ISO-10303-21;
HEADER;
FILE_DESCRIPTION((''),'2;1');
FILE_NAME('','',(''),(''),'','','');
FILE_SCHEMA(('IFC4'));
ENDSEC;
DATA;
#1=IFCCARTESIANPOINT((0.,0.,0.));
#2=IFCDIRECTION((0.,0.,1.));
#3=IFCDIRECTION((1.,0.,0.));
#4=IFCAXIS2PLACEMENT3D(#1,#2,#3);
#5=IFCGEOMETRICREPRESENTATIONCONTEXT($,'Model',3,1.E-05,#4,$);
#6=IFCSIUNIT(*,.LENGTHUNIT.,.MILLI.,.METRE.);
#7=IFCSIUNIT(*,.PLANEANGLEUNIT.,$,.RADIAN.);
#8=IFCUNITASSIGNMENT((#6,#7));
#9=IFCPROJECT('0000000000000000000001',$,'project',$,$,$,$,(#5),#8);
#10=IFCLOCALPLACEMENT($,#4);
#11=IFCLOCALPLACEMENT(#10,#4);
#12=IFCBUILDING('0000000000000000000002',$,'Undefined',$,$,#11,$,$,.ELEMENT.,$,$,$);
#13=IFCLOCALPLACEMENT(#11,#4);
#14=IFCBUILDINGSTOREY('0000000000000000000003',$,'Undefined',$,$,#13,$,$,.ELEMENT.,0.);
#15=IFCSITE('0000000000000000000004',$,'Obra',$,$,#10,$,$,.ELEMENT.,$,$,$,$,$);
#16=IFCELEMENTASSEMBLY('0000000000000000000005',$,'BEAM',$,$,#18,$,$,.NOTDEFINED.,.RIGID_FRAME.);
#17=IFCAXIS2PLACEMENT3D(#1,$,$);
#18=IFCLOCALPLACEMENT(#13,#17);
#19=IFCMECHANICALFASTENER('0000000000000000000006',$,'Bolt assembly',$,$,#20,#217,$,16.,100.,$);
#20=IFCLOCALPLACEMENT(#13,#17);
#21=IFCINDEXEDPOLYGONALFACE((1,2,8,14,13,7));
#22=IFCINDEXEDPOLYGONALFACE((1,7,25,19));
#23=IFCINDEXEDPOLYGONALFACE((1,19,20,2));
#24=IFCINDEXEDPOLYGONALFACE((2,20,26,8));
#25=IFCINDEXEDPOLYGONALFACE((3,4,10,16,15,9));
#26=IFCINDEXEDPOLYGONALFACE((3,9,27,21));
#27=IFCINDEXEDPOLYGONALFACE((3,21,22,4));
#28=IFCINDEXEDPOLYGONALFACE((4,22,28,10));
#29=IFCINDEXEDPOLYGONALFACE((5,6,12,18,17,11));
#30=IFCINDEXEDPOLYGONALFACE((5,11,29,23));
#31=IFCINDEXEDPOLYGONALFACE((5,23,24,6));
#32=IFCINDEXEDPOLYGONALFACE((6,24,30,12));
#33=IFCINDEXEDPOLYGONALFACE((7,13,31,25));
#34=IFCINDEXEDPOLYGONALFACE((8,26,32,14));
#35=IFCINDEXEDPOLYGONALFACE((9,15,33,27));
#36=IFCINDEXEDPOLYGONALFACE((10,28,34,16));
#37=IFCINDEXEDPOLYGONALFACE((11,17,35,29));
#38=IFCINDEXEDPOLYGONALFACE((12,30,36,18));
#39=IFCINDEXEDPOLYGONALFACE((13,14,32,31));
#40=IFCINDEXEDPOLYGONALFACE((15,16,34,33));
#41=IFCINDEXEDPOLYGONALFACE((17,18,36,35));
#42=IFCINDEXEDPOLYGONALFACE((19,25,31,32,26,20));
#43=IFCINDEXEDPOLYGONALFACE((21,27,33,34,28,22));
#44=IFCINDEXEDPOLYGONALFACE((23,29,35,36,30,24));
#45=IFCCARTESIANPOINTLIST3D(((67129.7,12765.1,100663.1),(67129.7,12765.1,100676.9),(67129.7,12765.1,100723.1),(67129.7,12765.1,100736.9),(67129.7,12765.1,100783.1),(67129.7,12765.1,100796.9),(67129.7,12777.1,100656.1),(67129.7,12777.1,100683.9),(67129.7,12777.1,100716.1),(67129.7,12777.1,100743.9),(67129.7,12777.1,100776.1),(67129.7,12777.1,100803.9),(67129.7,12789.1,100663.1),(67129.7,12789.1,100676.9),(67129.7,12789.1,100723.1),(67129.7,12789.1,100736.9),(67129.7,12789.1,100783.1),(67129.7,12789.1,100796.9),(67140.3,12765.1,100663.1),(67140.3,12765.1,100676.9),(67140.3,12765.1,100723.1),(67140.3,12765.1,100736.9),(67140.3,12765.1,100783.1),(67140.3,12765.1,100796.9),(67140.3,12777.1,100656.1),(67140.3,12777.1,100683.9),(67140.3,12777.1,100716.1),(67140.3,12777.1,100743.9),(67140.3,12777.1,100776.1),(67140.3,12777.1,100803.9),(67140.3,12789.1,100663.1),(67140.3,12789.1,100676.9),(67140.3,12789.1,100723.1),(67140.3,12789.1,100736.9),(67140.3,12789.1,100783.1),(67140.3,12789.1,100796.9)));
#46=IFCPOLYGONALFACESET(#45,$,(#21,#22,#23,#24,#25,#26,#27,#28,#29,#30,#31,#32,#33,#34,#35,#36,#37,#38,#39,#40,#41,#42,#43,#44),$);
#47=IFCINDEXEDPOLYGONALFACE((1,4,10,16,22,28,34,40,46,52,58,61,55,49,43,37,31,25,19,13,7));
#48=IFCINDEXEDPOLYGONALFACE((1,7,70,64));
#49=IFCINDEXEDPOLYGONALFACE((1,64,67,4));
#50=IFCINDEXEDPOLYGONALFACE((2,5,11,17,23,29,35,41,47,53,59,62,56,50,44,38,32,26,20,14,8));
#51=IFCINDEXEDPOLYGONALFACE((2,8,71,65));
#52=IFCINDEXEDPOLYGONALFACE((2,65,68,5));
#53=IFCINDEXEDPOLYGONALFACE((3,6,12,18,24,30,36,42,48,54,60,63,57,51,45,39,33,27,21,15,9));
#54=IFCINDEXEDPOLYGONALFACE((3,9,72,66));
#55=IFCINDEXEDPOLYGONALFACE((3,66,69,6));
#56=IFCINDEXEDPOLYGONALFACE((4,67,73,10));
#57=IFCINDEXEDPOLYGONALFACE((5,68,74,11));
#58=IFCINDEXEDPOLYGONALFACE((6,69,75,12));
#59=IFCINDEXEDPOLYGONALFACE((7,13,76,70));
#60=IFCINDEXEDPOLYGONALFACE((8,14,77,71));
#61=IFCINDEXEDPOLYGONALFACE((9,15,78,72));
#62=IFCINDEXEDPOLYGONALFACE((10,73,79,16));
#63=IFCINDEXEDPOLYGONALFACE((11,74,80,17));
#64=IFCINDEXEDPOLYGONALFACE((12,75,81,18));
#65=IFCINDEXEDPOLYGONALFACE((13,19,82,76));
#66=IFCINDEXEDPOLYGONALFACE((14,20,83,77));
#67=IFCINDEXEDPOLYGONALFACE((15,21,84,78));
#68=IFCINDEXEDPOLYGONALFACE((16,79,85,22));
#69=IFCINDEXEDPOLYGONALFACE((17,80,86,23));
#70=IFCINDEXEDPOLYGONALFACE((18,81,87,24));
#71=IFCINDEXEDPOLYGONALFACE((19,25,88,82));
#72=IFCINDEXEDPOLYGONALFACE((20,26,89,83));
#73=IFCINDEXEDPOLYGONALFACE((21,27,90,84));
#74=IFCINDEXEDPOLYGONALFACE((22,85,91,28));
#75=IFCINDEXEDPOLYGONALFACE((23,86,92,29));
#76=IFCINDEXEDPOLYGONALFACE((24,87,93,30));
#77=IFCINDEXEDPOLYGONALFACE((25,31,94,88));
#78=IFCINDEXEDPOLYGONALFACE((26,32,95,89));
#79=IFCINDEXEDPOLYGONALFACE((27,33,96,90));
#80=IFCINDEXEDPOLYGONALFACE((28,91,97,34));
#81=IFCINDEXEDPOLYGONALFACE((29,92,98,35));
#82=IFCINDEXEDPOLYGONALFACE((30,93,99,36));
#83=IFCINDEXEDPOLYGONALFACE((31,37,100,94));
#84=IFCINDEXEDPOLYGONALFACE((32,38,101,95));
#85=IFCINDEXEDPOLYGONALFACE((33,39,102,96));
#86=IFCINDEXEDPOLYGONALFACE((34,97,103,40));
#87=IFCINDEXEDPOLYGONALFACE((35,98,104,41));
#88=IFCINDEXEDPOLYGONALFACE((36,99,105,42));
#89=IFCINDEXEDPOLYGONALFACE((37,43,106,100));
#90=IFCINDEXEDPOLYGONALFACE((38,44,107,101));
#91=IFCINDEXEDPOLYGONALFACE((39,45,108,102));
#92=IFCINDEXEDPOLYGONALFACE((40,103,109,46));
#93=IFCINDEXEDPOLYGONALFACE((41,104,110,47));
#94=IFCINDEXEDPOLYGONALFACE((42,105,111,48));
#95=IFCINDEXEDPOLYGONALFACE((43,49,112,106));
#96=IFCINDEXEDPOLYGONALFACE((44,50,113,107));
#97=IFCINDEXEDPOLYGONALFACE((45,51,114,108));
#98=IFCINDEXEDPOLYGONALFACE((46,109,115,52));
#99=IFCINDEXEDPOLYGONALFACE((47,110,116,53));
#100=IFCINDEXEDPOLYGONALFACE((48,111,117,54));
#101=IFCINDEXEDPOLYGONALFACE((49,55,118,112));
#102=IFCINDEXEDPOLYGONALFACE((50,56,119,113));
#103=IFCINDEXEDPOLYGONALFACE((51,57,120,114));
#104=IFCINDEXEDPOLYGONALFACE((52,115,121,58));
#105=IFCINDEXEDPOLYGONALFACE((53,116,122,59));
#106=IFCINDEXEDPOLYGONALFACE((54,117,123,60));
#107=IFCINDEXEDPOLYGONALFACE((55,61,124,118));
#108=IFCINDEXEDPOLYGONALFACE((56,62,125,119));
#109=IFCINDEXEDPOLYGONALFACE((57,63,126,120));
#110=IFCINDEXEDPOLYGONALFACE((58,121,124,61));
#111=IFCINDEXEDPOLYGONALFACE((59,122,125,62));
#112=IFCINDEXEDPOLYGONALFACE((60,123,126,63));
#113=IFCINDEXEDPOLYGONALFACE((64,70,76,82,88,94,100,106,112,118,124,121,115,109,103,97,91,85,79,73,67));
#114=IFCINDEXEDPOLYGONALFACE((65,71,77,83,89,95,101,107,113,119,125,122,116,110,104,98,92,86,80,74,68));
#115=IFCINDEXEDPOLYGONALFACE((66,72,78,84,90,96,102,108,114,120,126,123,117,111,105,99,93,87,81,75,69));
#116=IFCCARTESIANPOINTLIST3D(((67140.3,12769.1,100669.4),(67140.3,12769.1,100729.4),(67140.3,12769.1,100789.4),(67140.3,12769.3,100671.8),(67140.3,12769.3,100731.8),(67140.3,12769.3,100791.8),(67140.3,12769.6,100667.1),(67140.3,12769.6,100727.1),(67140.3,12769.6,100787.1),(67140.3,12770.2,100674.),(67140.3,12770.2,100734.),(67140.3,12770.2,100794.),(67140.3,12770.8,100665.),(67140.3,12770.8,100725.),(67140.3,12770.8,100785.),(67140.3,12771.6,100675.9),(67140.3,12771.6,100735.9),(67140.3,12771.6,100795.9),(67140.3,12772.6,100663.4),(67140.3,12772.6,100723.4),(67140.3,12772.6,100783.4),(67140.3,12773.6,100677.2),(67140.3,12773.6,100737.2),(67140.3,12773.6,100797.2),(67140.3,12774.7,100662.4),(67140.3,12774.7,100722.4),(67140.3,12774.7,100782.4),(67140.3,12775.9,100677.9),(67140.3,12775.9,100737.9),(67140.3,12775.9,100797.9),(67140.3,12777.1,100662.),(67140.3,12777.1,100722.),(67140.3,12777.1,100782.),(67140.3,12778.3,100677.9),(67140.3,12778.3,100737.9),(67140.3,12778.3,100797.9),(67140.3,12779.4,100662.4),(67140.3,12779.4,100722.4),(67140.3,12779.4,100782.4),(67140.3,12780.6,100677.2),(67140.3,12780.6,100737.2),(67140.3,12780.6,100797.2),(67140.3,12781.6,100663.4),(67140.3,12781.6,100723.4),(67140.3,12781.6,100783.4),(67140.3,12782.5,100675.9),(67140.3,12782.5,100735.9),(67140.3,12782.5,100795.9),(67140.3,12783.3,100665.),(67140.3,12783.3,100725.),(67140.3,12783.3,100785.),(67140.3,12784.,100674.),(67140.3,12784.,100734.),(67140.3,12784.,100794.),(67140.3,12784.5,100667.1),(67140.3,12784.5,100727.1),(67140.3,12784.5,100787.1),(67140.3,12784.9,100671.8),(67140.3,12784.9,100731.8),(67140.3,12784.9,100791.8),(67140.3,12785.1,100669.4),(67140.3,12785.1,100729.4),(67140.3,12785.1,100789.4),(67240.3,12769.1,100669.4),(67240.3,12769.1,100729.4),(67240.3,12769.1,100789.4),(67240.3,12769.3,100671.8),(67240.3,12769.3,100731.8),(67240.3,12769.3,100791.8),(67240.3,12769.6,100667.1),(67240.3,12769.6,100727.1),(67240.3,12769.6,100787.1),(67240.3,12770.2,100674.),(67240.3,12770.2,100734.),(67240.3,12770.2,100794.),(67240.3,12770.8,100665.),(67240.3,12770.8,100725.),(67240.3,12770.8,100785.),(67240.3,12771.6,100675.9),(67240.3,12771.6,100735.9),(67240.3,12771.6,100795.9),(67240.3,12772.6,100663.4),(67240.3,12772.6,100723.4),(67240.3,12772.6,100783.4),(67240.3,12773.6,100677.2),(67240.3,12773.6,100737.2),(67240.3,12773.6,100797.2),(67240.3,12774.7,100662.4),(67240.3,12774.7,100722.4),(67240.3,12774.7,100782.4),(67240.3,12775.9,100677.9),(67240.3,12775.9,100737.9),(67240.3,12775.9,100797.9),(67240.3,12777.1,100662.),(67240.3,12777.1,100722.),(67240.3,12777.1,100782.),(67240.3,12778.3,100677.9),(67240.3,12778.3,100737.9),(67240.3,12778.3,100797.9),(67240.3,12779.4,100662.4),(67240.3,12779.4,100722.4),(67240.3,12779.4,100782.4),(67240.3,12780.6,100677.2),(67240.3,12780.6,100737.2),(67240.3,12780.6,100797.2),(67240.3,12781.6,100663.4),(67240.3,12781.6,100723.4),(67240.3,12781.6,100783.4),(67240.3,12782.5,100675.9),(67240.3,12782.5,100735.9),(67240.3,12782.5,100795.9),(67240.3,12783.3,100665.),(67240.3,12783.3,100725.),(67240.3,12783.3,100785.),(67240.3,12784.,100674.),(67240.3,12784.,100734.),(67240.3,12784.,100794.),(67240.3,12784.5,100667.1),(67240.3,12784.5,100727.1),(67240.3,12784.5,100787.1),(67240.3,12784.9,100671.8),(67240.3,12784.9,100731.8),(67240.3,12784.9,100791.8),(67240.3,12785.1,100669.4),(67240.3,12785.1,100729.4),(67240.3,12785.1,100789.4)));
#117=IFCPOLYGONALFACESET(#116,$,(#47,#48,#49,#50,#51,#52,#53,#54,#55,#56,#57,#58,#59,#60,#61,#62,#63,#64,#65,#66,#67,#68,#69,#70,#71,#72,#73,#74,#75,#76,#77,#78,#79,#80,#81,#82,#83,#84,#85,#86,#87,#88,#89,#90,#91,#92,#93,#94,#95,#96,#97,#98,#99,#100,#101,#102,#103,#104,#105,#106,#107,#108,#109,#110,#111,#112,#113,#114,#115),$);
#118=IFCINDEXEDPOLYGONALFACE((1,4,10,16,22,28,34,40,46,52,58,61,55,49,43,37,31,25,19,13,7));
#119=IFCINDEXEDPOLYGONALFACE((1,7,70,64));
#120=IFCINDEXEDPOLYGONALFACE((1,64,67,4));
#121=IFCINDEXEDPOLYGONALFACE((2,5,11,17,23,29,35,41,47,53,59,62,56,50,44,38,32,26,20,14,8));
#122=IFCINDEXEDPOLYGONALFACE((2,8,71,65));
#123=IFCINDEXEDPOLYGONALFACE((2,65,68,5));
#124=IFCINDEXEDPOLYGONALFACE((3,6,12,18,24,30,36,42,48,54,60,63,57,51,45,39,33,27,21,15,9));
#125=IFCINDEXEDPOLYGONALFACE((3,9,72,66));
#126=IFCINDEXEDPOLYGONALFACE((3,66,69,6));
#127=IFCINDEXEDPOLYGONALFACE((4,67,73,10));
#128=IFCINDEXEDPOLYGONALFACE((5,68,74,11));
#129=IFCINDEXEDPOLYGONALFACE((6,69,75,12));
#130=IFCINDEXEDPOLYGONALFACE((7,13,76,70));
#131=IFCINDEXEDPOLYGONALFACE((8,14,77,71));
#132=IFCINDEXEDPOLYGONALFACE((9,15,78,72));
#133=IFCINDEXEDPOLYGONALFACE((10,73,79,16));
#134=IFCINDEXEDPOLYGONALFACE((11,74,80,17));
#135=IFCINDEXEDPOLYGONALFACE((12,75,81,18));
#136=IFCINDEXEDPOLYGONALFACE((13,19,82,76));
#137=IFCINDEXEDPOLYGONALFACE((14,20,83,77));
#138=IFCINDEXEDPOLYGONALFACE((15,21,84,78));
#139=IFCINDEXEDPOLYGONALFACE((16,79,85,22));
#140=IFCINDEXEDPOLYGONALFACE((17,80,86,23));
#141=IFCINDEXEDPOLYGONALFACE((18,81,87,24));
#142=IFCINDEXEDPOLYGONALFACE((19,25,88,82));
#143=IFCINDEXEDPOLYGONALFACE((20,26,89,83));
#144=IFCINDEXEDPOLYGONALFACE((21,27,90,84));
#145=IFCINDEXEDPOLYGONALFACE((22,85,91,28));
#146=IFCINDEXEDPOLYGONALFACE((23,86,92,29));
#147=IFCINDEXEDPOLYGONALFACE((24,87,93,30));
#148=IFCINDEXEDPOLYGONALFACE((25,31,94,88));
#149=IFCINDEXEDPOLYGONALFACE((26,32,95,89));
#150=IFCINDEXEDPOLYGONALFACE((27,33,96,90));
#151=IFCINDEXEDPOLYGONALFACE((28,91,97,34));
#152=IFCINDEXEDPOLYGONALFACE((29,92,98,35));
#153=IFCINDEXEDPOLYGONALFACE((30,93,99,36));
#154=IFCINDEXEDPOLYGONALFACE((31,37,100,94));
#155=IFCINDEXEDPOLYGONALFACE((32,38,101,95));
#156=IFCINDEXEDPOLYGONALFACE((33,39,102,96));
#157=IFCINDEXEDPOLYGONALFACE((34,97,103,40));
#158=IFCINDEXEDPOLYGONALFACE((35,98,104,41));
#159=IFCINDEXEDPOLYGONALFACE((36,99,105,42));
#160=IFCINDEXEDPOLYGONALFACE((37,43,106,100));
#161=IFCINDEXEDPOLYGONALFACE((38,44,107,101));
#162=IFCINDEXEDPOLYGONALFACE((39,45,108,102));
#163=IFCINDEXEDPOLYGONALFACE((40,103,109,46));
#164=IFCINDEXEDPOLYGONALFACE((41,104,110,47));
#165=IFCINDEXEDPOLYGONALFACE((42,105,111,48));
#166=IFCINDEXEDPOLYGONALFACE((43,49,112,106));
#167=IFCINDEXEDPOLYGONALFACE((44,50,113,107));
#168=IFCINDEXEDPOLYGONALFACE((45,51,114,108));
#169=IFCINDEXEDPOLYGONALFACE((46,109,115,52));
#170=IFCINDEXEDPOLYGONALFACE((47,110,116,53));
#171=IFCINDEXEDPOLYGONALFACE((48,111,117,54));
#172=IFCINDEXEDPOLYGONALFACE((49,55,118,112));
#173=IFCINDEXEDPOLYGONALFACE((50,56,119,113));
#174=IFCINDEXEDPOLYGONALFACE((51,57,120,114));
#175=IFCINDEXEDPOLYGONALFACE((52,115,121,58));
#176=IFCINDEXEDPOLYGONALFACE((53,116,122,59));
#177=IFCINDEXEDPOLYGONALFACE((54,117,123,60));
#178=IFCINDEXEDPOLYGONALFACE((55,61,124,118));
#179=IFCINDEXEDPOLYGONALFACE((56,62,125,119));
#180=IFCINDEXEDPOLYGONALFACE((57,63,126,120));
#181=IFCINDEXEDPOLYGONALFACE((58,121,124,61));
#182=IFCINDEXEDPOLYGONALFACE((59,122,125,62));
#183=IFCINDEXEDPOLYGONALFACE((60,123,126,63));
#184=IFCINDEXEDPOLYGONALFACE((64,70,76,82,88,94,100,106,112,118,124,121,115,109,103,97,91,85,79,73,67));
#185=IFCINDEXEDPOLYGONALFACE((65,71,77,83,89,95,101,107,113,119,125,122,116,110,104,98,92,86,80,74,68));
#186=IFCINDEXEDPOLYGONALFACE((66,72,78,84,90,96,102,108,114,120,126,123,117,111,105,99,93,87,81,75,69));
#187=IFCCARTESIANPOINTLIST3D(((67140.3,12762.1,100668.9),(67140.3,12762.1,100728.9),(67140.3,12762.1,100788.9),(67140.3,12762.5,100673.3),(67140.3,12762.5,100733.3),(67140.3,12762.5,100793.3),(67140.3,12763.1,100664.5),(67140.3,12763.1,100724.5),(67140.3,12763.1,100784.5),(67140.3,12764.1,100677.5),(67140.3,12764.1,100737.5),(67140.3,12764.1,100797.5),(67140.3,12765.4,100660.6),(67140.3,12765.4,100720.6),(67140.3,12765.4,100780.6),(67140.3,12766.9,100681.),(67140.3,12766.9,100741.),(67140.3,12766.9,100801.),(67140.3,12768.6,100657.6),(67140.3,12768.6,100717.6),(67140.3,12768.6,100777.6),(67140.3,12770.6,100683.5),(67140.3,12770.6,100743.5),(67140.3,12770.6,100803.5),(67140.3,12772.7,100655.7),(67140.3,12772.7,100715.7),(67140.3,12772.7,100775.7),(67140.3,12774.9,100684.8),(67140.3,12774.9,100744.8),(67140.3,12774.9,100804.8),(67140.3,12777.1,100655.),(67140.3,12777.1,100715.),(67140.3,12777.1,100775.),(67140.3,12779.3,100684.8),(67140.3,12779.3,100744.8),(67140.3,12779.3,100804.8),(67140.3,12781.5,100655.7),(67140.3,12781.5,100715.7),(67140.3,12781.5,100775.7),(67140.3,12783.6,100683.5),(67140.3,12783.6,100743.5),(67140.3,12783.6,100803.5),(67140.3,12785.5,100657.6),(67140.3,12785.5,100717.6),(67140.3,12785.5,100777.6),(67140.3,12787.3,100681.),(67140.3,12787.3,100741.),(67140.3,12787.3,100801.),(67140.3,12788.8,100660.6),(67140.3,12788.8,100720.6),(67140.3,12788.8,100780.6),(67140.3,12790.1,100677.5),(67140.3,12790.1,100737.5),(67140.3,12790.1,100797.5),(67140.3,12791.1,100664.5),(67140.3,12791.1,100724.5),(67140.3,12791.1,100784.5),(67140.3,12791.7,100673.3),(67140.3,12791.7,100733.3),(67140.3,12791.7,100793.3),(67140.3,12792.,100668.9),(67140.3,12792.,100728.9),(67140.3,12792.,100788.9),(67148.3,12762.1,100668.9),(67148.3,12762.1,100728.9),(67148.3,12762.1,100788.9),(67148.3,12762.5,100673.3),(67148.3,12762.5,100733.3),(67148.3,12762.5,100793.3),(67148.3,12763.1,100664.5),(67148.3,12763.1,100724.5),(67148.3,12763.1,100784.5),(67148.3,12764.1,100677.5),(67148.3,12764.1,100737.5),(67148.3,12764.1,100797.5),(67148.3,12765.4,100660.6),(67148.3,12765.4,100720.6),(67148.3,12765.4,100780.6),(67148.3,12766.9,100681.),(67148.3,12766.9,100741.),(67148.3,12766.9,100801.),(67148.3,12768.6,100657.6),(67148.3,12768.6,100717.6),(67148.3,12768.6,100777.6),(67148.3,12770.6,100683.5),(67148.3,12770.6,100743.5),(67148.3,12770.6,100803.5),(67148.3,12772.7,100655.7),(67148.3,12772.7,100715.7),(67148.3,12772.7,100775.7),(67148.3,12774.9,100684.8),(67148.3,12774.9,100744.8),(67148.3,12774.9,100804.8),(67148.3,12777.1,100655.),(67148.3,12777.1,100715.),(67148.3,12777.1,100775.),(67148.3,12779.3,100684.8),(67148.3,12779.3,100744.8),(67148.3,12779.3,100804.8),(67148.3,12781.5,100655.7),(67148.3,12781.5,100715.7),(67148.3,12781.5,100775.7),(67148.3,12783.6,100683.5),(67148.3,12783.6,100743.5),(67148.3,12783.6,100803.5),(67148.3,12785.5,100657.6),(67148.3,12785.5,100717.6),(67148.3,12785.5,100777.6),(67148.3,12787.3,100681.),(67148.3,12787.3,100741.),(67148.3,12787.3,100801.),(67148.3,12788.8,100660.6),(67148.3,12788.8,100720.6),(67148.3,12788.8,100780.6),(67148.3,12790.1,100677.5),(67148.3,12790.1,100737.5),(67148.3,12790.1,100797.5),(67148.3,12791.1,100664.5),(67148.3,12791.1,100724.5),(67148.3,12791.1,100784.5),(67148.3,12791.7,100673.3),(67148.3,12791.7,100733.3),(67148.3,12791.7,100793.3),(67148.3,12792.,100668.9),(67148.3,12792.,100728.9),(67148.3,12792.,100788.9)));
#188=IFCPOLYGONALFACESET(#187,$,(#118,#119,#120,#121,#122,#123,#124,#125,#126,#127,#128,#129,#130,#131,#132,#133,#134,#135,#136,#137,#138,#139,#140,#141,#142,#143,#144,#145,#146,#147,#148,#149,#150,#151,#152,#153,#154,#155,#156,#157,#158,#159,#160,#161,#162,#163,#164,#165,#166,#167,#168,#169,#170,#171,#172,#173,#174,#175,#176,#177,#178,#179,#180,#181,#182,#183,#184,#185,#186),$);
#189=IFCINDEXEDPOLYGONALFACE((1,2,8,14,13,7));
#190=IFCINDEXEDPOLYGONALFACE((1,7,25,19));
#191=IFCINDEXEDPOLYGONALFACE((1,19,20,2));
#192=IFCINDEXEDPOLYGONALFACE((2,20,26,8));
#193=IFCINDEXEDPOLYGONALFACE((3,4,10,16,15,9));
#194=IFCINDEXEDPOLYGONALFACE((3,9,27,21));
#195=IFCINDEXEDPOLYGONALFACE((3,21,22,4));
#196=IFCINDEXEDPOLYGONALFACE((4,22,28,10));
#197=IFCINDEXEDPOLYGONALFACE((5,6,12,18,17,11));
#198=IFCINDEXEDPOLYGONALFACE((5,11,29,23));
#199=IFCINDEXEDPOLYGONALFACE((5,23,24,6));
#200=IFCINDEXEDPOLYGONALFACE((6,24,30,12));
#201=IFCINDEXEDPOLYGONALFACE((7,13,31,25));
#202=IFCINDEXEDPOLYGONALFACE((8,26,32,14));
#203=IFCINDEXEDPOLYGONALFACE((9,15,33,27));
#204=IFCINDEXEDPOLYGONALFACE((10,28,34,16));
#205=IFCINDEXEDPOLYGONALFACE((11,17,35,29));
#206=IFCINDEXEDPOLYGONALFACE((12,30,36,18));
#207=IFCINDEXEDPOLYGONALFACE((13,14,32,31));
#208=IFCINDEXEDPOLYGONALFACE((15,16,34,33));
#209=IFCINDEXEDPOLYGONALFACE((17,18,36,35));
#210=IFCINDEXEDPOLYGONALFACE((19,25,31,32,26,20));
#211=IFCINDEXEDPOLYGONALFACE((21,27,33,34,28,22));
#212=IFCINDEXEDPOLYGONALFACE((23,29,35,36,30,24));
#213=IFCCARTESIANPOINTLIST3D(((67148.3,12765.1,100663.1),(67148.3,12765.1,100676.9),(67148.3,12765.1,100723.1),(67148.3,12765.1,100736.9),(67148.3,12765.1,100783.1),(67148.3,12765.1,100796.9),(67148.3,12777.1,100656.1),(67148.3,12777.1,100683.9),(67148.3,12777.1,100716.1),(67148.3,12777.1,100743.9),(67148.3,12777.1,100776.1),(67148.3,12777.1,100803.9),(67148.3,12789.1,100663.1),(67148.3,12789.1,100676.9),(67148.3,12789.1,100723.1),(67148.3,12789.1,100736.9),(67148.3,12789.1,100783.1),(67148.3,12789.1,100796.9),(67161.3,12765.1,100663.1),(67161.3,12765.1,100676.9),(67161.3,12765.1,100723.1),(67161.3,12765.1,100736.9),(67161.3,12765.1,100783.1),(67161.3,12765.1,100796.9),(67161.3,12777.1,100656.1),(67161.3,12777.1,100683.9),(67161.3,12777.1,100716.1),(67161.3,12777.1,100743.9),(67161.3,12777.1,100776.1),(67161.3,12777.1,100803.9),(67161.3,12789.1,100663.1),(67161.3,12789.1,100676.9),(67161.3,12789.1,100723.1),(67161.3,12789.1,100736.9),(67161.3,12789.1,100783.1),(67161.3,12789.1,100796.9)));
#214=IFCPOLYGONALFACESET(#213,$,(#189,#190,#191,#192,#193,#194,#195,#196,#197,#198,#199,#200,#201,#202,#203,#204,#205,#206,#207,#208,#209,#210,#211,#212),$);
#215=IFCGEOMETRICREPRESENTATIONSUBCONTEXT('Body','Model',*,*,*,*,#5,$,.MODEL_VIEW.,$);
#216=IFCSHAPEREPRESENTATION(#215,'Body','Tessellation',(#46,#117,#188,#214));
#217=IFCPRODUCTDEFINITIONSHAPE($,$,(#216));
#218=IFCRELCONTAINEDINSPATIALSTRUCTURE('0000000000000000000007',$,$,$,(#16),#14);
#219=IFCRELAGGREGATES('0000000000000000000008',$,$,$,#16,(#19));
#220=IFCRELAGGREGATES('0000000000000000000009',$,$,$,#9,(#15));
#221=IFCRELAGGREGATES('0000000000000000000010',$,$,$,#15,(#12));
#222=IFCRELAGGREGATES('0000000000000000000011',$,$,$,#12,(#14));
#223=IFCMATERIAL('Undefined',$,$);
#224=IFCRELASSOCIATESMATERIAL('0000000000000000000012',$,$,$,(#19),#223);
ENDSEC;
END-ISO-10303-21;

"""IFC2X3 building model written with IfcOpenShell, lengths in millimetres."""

from ifc_helpers import new_model, si_unit, frame, origin_with_axes, origin_2d_with_axis, place, context, subcontext, project, spatial, polyline, circle, outline, extrude, source, transform, mapped, material, element, aggregate, save


model = new_model("IFC2X3")

# Units and contexts
model_context = context("Model", 3, precision=1e-05, world=origin_with_axes())
body_context = subcontext(model_context, "Body", "Model", "MODEL_VIEW")
ifc_project = project(units=[si_unit("LENGTHUNIT", "METRE", prefix="MILLI"), si_unit("PLANEANGLEUNIT", "RADIAN")], contexts=[model_context])

# Site, building, storey
site_placement = place(None, origin_with_axes())
site = spatial("IfcSite", under=ifc_project, at=site_placement, Name="Obra", CompositionType="ELEMENT")
building_placement = place(site_placement, origin_with_axes())
building = spatial("IfcBuilding", under=site, at=building_placement, Name="Undefined", CompositionType="ELEMENT")
storey_placement = place(building_placement, origin_with_axes())
storey = spatial("IfcBuildingStorey", under=building, at=storey_placement, Name="Undefined", CompositionType="ELEMENT", Elevation=0.0)

# Shared definitions
ifc_material_1 = material(Name="Undefined")

# Element assembly, mechanical fastener
shared_shape_1 = source(origin_with_axes(), body_context, "Body", "SweptSolid", [
    extrude(outline(polyline([(13.9, 0.0), (6.9, 12.0), (-6.9, 12.0), (-13.9, 0.0), (-6.9, -12.0), (6.9, -12.0), (13.9, 0.0)])), frame((0.0, -10.6, 0.0), z_axis=(0.0, 1.0, 0.0), x_axis=(1.0, 0.0, 0.0)), (0.0, 0.0, 1.0), 10.6),
    extrude(circle(Radius=8.0, at=origin_2d_with_axis()), frame((0.0, 0.0, 0.0), z_axis=(0.0, 1.0, 0.0), x_axis=(1.0, 0.0, 0.0)), (0.0, 0.0, 1.0), 100.0),
    extrude(circle(Radius=15.0, at=origin_2d_with_axis()), frame((0.0, 0.0, 0.0), z_axis=(0.0, 1.0, 0.0), x_axis=(1.0, 0.0, 0.0)), (0.0, 0.0, 1.0), 8.0),
    extrude(outline(polyline([(13.9, 0.0), (6.9, 12.0), (-6.9, 12.0), (-13.9, 0.0), (-6.9, -12.0), (6.9, -12.0), (13.9, 0.0)])), frame((0.0, 8.0, 0.0), z_axis=(0.0, 1.0, 0.0), x_axis=(1.0, 0.0, 0.0)), (0.0, 0.0, 1.0), 13.0),
])
assembly_1_placement = place(storey_placement, origin_with_axes())
assembly_1 = element("IfcElementAssembly", 1, at=assembly_1_placement, inside=storey, Name="BEAM", AssemblyPlace="NOTDEFINED", PredefinedType="RIGID_FRAME")
mechanical_fastener_1_placement = place(assembly_1_placement, frame((67140.3, 12827.1, 100850.0), z_axis=(0.0, -1.0, 0.0), x_axis=(0.0, 0.0, -1.0)))
mechanical_fastener_1 = element("IfcMechanicalFastener", 2, at=mechanical_fastener_1_placement, material=ifc_material_1, Name="Bolt assembly", NominalDiameter=16.0, NominalLength=100.0, context=body_context, shape_type="MappedRepresentation", body=[
    mapped(shared_shape_1, transform((60.0, 0.0, 50.0))),
    mapped(shared_shape_1, transform((120.0, 0.0, 50.0))),
    mapped(shared_shape_1, transform((180.0, 0.0, 50.0))),
])
aggregate(assembly_1, [mechanical_fastener_1])

save(model, "model.ifc")
